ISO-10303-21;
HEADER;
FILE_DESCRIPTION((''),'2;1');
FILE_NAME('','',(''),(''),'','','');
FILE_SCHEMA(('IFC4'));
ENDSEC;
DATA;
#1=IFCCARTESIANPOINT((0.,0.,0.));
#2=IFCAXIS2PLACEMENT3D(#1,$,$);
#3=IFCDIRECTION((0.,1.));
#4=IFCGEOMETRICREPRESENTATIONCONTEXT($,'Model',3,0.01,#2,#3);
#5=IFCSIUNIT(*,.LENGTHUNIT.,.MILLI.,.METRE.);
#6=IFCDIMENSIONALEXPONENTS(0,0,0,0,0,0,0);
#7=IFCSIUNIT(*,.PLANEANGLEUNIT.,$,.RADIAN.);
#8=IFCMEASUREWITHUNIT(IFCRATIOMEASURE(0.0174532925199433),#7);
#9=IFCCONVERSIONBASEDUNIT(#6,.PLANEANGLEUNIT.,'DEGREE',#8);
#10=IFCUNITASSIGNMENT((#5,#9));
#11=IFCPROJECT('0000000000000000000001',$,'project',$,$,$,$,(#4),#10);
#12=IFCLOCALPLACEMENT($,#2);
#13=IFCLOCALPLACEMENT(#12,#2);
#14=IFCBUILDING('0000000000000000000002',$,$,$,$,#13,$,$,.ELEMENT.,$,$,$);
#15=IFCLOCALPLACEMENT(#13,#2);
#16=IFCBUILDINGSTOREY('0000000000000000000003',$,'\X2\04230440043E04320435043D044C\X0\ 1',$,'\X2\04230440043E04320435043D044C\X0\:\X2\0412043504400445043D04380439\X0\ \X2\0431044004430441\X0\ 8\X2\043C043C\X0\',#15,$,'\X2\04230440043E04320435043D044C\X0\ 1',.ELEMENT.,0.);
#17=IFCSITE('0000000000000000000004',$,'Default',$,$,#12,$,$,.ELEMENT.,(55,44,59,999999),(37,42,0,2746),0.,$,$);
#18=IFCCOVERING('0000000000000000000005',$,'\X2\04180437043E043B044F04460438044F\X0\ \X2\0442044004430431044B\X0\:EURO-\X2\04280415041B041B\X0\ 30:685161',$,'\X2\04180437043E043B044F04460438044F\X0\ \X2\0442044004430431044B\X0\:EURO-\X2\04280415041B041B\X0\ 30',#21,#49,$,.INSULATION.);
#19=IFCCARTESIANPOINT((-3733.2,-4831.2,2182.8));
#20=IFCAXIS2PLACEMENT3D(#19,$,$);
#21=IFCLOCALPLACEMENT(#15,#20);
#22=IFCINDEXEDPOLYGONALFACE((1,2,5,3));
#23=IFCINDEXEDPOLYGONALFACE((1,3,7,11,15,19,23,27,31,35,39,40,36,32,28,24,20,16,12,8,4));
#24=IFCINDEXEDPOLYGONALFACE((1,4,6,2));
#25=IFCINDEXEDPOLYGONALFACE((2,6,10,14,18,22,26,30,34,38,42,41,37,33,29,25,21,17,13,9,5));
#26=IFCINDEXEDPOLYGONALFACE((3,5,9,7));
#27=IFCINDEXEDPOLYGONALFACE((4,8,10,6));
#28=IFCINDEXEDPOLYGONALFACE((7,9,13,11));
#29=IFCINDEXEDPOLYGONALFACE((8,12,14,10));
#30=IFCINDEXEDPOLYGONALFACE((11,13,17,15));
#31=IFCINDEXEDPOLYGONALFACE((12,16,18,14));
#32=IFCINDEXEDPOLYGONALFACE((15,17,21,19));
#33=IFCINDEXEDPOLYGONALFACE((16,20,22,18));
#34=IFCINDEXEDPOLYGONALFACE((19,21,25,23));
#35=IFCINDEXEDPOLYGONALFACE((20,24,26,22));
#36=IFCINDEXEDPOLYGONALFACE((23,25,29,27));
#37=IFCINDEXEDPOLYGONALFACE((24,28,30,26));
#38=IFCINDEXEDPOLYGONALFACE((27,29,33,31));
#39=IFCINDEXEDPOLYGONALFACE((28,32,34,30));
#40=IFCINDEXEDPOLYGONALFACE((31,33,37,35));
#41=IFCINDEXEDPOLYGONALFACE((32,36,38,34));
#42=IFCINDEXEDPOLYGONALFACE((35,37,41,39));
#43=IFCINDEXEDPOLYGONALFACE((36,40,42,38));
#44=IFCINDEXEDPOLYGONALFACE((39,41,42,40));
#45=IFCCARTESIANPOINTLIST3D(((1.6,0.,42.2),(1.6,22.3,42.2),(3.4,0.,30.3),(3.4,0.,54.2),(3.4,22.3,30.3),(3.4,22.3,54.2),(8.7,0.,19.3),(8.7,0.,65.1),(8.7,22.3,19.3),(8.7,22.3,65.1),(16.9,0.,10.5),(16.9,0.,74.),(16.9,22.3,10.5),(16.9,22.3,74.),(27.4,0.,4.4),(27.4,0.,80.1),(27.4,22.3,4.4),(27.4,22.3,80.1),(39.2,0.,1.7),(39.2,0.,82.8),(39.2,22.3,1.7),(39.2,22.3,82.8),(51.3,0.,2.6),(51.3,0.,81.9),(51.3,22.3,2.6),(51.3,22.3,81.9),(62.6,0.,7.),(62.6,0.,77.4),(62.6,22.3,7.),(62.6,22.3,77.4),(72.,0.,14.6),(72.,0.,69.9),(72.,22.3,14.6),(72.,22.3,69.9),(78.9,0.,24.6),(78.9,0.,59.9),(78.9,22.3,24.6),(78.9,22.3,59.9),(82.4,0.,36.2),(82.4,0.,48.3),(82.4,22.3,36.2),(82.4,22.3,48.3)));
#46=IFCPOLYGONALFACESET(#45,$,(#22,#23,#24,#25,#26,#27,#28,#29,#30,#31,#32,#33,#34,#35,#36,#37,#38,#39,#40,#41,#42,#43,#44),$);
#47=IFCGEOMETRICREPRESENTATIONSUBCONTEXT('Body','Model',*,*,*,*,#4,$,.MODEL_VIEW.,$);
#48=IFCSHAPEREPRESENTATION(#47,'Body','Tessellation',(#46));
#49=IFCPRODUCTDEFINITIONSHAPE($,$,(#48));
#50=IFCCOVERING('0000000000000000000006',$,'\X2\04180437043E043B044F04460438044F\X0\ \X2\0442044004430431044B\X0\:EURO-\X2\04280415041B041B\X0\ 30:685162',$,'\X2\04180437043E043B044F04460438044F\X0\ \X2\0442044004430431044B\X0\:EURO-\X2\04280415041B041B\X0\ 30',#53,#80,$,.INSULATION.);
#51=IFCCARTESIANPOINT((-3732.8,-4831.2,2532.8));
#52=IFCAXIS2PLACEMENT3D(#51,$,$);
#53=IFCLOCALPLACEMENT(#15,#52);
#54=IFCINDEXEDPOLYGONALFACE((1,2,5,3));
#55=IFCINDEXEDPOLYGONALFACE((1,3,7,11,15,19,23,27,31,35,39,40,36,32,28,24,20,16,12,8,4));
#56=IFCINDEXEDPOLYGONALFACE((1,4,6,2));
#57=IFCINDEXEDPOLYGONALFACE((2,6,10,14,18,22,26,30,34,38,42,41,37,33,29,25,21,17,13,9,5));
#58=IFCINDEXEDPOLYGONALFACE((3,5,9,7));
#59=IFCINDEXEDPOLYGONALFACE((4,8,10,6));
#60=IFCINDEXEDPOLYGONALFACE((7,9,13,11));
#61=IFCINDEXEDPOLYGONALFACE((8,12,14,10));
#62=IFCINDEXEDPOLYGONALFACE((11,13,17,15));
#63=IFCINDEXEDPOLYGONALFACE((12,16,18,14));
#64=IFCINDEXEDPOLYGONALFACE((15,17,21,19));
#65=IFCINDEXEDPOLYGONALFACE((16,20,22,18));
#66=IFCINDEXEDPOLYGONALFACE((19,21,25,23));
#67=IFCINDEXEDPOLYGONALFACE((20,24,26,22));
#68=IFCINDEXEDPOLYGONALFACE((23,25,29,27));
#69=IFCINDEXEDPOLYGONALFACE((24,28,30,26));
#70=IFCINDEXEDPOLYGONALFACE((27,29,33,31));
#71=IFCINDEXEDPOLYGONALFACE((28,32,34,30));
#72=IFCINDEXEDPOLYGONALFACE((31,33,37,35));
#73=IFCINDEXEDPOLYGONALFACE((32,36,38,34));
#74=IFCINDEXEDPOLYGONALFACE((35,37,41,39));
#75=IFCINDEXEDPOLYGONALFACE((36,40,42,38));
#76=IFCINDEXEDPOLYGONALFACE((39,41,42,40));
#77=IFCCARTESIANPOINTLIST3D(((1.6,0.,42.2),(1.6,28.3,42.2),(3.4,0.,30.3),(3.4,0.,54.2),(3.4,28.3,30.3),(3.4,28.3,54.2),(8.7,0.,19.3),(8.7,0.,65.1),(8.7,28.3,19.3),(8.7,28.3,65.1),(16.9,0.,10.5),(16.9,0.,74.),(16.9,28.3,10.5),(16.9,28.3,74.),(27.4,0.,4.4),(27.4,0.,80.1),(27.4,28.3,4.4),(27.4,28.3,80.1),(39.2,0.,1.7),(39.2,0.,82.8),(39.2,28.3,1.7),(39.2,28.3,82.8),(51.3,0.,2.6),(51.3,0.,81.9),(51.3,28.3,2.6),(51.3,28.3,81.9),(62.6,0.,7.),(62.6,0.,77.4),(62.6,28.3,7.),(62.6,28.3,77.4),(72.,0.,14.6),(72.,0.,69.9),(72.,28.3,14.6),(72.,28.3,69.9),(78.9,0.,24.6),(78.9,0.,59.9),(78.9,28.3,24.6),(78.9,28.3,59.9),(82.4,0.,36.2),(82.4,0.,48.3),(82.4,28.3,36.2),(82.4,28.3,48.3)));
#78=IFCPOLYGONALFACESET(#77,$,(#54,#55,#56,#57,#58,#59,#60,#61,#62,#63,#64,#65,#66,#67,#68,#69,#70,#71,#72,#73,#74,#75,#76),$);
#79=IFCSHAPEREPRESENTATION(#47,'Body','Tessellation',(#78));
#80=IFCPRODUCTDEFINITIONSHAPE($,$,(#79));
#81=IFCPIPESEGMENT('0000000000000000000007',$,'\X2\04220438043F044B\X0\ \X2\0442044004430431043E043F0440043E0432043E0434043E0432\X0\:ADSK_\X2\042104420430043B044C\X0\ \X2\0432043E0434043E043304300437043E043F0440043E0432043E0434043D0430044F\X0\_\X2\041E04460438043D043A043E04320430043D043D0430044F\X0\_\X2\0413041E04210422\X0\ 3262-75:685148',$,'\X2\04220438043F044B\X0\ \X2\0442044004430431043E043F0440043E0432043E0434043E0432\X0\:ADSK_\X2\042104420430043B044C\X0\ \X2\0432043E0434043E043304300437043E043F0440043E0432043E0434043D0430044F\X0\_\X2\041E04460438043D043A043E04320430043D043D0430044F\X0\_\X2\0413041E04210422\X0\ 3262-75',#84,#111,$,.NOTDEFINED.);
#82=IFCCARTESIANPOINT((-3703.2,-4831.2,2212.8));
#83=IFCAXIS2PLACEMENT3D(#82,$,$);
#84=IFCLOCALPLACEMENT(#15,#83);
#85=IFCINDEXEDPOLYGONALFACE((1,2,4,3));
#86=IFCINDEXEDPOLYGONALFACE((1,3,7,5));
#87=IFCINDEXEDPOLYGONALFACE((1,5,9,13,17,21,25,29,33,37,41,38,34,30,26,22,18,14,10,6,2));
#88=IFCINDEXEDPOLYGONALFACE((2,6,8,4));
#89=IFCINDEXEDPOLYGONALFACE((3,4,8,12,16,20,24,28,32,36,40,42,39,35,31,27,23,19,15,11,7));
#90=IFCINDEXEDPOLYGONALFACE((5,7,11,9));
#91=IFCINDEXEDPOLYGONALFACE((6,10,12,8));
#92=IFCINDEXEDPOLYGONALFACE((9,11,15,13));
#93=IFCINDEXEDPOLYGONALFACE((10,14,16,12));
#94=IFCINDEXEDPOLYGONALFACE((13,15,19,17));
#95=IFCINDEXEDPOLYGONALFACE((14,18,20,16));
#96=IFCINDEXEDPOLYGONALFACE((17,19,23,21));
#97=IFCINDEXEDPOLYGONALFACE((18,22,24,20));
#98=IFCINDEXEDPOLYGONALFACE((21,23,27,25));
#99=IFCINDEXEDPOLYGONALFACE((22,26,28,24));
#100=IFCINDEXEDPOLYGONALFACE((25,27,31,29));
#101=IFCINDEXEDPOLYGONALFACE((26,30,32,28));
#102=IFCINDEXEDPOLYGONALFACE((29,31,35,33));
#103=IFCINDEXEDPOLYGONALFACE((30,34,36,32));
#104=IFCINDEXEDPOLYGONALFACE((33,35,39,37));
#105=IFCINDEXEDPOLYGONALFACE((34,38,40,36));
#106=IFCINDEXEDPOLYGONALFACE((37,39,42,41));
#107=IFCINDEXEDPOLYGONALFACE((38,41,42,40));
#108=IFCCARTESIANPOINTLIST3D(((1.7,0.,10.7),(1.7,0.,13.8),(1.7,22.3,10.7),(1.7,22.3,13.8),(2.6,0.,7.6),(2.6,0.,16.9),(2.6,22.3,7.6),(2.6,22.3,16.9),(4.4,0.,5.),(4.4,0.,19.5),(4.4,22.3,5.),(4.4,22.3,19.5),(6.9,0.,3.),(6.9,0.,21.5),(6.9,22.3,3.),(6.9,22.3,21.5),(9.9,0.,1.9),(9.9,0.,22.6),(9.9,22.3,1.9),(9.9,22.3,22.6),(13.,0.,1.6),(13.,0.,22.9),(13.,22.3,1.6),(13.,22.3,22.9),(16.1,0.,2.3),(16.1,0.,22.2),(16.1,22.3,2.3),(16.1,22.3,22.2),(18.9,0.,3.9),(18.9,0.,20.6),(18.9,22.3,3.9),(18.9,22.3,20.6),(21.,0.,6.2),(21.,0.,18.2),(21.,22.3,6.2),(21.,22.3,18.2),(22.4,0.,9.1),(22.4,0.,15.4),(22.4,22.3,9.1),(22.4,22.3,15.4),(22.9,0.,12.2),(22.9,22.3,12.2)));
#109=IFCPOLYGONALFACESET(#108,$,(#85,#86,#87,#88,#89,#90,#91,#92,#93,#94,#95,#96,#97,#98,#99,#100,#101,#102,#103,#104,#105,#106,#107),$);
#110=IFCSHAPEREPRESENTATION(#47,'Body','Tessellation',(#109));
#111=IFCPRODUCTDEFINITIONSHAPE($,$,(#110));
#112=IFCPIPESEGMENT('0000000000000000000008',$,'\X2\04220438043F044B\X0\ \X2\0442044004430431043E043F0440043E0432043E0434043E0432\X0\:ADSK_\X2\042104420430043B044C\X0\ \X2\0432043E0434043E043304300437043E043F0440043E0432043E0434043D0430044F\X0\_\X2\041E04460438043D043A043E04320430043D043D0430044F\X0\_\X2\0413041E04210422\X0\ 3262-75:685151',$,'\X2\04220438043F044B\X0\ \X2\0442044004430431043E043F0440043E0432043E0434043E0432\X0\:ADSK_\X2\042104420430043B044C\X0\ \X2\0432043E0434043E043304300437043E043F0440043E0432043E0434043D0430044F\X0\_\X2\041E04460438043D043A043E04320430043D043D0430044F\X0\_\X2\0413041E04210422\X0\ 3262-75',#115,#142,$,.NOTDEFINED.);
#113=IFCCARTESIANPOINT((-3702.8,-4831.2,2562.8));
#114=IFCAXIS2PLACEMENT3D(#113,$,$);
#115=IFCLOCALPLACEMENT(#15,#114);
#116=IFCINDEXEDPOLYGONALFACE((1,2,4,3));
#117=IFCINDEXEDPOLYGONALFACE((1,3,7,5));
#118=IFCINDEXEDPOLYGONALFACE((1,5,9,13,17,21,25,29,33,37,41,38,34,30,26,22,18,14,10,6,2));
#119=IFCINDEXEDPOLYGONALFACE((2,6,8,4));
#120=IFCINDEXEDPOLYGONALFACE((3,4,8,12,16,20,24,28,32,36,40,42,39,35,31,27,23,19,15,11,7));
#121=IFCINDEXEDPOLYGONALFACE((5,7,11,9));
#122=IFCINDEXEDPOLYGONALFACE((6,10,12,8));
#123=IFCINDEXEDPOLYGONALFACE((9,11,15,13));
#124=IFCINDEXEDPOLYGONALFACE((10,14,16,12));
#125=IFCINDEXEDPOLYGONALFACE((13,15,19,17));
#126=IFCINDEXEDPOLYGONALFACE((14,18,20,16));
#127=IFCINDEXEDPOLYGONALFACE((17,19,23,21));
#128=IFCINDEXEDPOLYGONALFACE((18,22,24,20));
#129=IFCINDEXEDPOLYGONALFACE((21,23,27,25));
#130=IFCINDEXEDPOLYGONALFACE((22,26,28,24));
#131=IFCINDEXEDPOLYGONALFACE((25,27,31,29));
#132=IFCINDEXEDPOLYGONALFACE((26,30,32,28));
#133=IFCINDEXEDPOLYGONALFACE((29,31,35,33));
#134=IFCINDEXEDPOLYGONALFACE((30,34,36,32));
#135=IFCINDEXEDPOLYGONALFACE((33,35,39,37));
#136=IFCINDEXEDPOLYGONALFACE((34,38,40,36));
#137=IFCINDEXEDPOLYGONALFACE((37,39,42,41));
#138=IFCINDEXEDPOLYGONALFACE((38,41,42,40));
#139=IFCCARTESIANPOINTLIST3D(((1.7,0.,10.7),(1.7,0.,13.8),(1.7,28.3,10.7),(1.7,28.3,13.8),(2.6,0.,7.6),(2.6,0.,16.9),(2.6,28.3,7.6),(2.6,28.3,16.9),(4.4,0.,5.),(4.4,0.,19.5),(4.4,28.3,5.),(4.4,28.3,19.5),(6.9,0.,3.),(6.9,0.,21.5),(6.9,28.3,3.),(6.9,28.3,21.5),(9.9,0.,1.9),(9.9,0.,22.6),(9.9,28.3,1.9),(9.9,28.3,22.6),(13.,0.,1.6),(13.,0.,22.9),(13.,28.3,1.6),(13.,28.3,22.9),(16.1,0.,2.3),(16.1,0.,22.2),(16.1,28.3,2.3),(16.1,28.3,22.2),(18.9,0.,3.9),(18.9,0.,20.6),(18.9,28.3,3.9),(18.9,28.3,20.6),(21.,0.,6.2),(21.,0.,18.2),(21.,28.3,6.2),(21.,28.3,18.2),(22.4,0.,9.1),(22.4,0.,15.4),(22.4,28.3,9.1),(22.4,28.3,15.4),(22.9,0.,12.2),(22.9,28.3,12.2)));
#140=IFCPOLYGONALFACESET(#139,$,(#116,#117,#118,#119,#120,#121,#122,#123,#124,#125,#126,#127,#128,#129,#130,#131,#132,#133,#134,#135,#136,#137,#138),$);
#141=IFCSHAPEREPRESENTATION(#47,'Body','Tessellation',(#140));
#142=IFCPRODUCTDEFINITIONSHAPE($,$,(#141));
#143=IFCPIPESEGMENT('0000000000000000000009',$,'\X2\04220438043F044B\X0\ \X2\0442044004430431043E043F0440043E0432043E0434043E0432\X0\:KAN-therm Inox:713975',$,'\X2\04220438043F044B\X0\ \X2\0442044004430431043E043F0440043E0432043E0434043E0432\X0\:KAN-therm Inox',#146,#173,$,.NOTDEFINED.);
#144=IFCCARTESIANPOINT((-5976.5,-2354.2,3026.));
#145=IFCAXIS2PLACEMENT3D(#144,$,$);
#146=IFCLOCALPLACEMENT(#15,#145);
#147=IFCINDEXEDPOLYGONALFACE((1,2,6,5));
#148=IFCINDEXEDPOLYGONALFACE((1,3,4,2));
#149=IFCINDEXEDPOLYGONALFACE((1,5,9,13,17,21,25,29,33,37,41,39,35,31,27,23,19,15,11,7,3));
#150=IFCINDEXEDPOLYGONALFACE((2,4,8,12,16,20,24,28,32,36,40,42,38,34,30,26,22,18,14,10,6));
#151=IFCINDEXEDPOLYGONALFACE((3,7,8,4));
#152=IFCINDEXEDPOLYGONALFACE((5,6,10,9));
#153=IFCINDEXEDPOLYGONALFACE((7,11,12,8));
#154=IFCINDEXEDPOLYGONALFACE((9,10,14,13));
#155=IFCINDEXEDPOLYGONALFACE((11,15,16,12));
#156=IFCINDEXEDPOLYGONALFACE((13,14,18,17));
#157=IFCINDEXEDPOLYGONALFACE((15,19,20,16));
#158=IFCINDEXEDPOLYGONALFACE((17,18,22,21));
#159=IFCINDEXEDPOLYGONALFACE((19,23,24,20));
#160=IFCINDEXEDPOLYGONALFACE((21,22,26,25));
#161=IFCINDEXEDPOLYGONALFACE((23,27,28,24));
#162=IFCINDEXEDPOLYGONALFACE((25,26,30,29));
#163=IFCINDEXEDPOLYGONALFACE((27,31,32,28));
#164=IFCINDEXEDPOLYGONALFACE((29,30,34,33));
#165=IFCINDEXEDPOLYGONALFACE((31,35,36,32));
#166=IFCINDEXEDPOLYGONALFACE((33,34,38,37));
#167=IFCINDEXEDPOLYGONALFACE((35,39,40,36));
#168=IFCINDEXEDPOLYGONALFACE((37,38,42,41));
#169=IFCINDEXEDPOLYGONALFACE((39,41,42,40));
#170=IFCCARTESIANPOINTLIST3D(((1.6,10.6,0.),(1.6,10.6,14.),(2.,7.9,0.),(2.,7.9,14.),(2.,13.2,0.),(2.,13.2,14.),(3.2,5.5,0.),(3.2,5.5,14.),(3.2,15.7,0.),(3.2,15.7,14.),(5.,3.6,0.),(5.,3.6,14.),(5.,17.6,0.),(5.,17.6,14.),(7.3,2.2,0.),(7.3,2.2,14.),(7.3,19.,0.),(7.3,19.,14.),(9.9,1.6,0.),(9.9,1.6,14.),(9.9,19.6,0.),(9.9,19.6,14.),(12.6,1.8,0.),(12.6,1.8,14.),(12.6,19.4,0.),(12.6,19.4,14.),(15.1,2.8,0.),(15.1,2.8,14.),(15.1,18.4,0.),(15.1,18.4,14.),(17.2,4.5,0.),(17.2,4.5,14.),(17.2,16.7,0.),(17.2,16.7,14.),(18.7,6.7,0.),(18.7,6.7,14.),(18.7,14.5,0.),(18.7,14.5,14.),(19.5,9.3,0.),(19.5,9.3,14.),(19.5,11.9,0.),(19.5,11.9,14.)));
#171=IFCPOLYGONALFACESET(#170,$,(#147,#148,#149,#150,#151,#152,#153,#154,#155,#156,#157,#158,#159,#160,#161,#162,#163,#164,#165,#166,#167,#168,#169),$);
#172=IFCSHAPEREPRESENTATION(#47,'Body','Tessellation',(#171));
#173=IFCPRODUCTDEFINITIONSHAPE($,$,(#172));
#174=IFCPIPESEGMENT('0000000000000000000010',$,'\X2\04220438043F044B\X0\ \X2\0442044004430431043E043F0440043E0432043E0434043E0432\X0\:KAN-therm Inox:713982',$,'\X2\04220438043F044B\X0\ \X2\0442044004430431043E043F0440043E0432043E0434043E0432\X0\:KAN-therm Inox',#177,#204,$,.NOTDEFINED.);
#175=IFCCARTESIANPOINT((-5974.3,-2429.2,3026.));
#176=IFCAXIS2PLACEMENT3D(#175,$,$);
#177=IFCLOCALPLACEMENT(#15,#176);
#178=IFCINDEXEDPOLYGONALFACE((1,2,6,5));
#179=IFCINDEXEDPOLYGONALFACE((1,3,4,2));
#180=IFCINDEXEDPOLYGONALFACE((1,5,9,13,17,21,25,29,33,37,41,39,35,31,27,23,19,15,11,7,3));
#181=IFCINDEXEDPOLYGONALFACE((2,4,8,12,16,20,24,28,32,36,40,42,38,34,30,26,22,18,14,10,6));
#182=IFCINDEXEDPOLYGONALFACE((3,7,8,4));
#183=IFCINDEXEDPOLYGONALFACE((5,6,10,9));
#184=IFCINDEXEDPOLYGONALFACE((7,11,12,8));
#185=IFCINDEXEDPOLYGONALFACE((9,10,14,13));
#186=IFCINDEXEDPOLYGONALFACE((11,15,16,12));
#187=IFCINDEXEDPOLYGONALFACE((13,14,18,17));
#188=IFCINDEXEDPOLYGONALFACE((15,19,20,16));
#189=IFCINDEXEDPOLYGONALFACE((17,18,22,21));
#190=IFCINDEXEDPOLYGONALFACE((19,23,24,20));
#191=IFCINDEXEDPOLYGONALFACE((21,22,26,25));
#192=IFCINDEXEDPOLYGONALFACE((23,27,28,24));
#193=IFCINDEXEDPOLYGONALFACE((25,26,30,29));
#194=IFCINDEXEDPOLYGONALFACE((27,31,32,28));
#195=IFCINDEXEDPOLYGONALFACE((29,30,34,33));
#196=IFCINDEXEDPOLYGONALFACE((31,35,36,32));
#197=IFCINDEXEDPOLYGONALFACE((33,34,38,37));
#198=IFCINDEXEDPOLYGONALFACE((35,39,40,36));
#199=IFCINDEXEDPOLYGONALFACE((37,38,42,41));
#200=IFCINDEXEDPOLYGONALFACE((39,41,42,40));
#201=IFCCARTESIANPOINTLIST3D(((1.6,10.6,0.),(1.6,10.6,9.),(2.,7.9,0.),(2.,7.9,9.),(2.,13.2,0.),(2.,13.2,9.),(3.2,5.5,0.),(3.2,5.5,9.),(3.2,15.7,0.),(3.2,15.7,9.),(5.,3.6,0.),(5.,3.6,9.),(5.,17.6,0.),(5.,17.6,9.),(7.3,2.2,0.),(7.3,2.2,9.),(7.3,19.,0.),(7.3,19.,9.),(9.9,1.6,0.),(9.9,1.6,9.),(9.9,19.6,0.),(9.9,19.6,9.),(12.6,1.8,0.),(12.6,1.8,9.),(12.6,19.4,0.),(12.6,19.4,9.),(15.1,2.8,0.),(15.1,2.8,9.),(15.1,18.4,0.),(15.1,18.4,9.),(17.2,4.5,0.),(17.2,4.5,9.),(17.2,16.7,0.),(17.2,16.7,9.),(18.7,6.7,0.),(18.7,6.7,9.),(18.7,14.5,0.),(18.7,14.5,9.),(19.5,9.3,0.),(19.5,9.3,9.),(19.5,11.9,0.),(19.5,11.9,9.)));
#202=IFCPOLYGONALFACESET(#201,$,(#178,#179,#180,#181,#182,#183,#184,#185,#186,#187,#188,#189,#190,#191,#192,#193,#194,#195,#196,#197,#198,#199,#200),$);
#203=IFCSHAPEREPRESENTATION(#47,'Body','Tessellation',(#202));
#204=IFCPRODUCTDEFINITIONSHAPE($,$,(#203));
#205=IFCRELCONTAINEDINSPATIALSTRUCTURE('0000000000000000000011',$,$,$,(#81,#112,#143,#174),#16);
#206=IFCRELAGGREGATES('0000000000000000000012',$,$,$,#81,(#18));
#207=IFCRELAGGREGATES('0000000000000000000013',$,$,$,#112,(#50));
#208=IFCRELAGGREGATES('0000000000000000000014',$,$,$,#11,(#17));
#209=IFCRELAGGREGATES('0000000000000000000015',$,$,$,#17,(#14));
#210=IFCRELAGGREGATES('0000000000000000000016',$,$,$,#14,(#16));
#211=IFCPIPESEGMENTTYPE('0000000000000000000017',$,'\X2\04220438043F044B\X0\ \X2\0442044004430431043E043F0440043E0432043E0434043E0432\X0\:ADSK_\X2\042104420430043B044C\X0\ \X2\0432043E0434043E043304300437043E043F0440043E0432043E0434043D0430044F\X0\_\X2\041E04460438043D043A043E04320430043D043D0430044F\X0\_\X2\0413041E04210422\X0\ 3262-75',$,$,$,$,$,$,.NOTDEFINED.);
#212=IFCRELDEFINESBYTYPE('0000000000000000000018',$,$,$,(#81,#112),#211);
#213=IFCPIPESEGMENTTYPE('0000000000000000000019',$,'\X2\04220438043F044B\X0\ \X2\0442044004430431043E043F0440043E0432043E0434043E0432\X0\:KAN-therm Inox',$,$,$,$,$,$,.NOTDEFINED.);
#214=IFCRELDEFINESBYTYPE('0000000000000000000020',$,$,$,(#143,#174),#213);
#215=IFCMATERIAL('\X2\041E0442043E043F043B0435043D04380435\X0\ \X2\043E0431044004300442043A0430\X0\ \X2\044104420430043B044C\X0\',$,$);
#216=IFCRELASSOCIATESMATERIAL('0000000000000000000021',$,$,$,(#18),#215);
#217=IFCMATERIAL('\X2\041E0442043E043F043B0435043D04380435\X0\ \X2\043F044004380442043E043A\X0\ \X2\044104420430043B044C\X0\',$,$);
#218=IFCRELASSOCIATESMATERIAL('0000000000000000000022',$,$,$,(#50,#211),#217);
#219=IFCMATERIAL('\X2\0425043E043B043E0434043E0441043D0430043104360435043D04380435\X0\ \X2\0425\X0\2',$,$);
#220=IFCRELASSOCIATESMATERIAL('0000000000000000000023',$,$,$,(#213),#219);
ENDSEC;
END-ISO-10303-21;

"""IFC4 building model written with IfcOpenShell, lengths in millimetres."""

from ifc_helpers import new_model, entity, si_unit, converted_unit, direction, frame, origin, origin_2d_with_axis, place, context, subcontext, project, spatial, circle, extrude, material, type_object, element, aggregate, save


model = new_model("IFC4")

# Units and contexts
model_context = context("Model", 3, precision=0.01, world=origin(), true_north=direction((0.0, 1.0)))
body_context = subcontext(model_context, "Body", "Model", "MODEL_VIEW")
ifc_project = project(units=[si_unit("LENGTHUNIT", "METRE", prefix="MILLI"), converted_unit("PLANEANGLEUNIT", "DEGREE", entity("IfcRatioMeasure", 0.0174532925199433), si_unit("PLANEANGLEUNIT", "RADIAN"), dimensions=[0, 0, 0, 0, 0, 0, 0])], contexts=[model_context])

# Site, building, storey
site_placement = place(None, origin())
site = spatial("IfcSite", under=ifc_project, at=site_placement, Name="Default", CompositionType="ELEMENT", RefLatitude=(55, 44, 59, 999999), RefLongitude=(37, 42, 0, 2746), RefElevation=0.0)
building_placement = place(site_placement, origin())
building = spatial("IfcBuilding", under=site, at=building_placement, CompositionType="ELEMENT")
storey_placement = place(building_placement, origin())
storey = spatial("IfcBuildingStorey", under=building, at=storey_placement, Name="Уровень 1", ObjectType="Уровень:Верхний брус 8мм", LongName="Уровень 1", CompositionType="ELEMENT", Elevation=0.0)

# Coverings
ifc_material_1 = material(Name="Отопление обратка сталь")
covering_1_placement = place(storey_placement, frame((-3733.2, -4831.2, 2182.8)))
covering_1 = element("IfcCovering", 1, at=covering_1_placement, material=ifc_material_1, Name="Изоляция трубы:EURO-ШЕЛЛ 30:685161", ObjectType="Изоляция трубы:EURO-ШЕЛЛ 30", PredefinedType="INSULATION", context=body_context, shape_type="SweptSolid", body=[
    extrude(circle(Radius=40.6, at=origin_2d_with_axis()), frame((42.2, 0.0, 42.2), z_axis=(0.0, 1.0, 0.0), x_axis=(-1.0, 0.0, 0.0)), (0.0, 0.0, 1.0), 22.3),
])
ifc_material_2 = material(Name="Отопление приток сталь")
covering_2_placement = place(storey_placement, frame((-3732.8, -4831.2, 2532.8)))
covering_2 = element("IfcCovering", 2, at=covering_2_placement, material=ifc_material_2, Name="Изоляция трубы:EURO-ШЕЛЛ 30:685162", ObjectType="Изоляция трубы:EURO-ШЕЛЛ 30", PredefinedType="INSULATION", context=body_context, shape_type="SweptSolid", body=[
    extrude(circle(Radius=40.6, at=origin_2d_with_axis()), frame((42.2, 0.0, 42.2), z_axis=(0.0, 1.0, 0.0), x_axis=(-1.0, 0.0, 0.0)), (0.0, 0.0, 1.0), 28.3),
])
ifc_material_3 = material(Name="Холодоснабжение Х2")

# Pipe segments
pipe_segment_type_1 = type_object("IfcPipeSegmentType", Name="Типы трубопроводов:ADSK_Сталь водогазопроводная_Оцинкованная_ГОСТ 3262-75", PredefinedType="NOTDEFINED", material=ifc_material_2)
pipe_segment_1_placement = place(storey_placement, frame((-3703.2, -4831.2, 2212.8)))
pipe_segment_1 = element("IfcPipeSegment", 3, at=pipe_segment_1_placement, inside=storey, type_object=pipe_segment_type_1, Name="Типы трубопроводов:ADSK_Сталь водогазопроводная_Оцинкованная_ГОСТ 3262-75:685148", ObjectType="Типы трубопроводов:ADSK_Сталь водогазопроводная_Оцинкованная_ГОСТ 3262-75", PredefinedType="NOTDEFINED", context=body_context, shape_type="SweptSolid", body=[
    extrude(circle(Radius=10.7, at=origin_2d_with_axis()), frame((12.2, 0.0, 12.2), z_axis=(0.0, 1.0, 0.0), x_axis=(1.0, 0.0, 0.0)), (0.0, 0.0, 1.0), 22.3),
])
aggregate(pipe_segment_1, [covering_1])
pipe_segment_2_placement = place(storey_placement, frame((-3702.8, -4831.2, 2562.8)))
pipe_segment_2 = element("IfcPipeSegment", 4, at=pipe_segment_2_placement, inside=storey, type_object=pipe_segment_type_1, Name="Типы трубопроводов:ADSK_Сталь водогазопроводная_Оцинкованная_ГОСТ 3262-75:685151", ObjectType="Типы трубопроводов:ADSK_Сталь водогазопроводная_Оцинкованная_ГОСТ 3262-75", PredefinedType="NOTDEFINED", context=body_context, shape_type="SweptSolid", body=[
    extrude(circle(Radius=10.7, at=origin_2d_with_axis()), frame((12.2, 0.0, 12.2), z_axis=(0.0, 1.0, 0.0), x_axis=(1.0, 0.0, 0.0)), (0.0, 0.0, 1.0), 28.3),
])
aggregate(pipe_segment_2, [covering_2])
pipe_segment_type_2 = type_object("IfcPipeSegmentType", Name="Типы трубопроводов:KAN-therm Inox", PredefinedType="NOTDEFINED", material=ifc_material_3)
pipe_segment_3_placement = place(storey_placement, frame((-5976.5, -2354.2, 3026.0)))
element("IfcPipeSegment", 5, at=pipe_segment_3_placement, inside=storey, type_object=pipe_segment_type_2, Name="Типы трубопроводов:KAN-therm Inox:713975", ObjectType="Типы трубопроводов:KAN-therm Inox", PredefinedType="NOTDEFINED", context=body_context, shape_type="SweptSolid", body=[
    extrude(circle(Radius=9.0, at=origin_2d_with_axis()), frame((10.6, 10.6, 0.0), z_axis=(0.0, 0.0, 1.0), x_axis=(-1.0, 0.0, 0.0)), (0.0, 0.0, 1.0), 14.0),
])
pipe_segment_4_placement = place(storey_placement, frame((-5974.3, -2429.2, 3026.0)))
element("IfcPipeSegment", 6, at=pipe_segment_4_placement, inside=storey, type_object=pipe_segment_type_2, Name="Типы трубопроводов:KAN-therm Inox:713982", ObjectType="Типы трубопроводов:KAN-therm Inox", PredefinedType="NOTDEFINED", context=body_context, shape_type="SweptSolid", body=[
    extrude(circle(Radius=9.0, at=origin_2d_with_axis()), frame((10.6, 10.6, 0.0), z_axis=(0.0, 0.0, 1.0), x_axis=(-1.0, 0.0, 0.0)), (0.0, 0.0, 1.0), 9.0),
])

save(model, "model.ifc")
